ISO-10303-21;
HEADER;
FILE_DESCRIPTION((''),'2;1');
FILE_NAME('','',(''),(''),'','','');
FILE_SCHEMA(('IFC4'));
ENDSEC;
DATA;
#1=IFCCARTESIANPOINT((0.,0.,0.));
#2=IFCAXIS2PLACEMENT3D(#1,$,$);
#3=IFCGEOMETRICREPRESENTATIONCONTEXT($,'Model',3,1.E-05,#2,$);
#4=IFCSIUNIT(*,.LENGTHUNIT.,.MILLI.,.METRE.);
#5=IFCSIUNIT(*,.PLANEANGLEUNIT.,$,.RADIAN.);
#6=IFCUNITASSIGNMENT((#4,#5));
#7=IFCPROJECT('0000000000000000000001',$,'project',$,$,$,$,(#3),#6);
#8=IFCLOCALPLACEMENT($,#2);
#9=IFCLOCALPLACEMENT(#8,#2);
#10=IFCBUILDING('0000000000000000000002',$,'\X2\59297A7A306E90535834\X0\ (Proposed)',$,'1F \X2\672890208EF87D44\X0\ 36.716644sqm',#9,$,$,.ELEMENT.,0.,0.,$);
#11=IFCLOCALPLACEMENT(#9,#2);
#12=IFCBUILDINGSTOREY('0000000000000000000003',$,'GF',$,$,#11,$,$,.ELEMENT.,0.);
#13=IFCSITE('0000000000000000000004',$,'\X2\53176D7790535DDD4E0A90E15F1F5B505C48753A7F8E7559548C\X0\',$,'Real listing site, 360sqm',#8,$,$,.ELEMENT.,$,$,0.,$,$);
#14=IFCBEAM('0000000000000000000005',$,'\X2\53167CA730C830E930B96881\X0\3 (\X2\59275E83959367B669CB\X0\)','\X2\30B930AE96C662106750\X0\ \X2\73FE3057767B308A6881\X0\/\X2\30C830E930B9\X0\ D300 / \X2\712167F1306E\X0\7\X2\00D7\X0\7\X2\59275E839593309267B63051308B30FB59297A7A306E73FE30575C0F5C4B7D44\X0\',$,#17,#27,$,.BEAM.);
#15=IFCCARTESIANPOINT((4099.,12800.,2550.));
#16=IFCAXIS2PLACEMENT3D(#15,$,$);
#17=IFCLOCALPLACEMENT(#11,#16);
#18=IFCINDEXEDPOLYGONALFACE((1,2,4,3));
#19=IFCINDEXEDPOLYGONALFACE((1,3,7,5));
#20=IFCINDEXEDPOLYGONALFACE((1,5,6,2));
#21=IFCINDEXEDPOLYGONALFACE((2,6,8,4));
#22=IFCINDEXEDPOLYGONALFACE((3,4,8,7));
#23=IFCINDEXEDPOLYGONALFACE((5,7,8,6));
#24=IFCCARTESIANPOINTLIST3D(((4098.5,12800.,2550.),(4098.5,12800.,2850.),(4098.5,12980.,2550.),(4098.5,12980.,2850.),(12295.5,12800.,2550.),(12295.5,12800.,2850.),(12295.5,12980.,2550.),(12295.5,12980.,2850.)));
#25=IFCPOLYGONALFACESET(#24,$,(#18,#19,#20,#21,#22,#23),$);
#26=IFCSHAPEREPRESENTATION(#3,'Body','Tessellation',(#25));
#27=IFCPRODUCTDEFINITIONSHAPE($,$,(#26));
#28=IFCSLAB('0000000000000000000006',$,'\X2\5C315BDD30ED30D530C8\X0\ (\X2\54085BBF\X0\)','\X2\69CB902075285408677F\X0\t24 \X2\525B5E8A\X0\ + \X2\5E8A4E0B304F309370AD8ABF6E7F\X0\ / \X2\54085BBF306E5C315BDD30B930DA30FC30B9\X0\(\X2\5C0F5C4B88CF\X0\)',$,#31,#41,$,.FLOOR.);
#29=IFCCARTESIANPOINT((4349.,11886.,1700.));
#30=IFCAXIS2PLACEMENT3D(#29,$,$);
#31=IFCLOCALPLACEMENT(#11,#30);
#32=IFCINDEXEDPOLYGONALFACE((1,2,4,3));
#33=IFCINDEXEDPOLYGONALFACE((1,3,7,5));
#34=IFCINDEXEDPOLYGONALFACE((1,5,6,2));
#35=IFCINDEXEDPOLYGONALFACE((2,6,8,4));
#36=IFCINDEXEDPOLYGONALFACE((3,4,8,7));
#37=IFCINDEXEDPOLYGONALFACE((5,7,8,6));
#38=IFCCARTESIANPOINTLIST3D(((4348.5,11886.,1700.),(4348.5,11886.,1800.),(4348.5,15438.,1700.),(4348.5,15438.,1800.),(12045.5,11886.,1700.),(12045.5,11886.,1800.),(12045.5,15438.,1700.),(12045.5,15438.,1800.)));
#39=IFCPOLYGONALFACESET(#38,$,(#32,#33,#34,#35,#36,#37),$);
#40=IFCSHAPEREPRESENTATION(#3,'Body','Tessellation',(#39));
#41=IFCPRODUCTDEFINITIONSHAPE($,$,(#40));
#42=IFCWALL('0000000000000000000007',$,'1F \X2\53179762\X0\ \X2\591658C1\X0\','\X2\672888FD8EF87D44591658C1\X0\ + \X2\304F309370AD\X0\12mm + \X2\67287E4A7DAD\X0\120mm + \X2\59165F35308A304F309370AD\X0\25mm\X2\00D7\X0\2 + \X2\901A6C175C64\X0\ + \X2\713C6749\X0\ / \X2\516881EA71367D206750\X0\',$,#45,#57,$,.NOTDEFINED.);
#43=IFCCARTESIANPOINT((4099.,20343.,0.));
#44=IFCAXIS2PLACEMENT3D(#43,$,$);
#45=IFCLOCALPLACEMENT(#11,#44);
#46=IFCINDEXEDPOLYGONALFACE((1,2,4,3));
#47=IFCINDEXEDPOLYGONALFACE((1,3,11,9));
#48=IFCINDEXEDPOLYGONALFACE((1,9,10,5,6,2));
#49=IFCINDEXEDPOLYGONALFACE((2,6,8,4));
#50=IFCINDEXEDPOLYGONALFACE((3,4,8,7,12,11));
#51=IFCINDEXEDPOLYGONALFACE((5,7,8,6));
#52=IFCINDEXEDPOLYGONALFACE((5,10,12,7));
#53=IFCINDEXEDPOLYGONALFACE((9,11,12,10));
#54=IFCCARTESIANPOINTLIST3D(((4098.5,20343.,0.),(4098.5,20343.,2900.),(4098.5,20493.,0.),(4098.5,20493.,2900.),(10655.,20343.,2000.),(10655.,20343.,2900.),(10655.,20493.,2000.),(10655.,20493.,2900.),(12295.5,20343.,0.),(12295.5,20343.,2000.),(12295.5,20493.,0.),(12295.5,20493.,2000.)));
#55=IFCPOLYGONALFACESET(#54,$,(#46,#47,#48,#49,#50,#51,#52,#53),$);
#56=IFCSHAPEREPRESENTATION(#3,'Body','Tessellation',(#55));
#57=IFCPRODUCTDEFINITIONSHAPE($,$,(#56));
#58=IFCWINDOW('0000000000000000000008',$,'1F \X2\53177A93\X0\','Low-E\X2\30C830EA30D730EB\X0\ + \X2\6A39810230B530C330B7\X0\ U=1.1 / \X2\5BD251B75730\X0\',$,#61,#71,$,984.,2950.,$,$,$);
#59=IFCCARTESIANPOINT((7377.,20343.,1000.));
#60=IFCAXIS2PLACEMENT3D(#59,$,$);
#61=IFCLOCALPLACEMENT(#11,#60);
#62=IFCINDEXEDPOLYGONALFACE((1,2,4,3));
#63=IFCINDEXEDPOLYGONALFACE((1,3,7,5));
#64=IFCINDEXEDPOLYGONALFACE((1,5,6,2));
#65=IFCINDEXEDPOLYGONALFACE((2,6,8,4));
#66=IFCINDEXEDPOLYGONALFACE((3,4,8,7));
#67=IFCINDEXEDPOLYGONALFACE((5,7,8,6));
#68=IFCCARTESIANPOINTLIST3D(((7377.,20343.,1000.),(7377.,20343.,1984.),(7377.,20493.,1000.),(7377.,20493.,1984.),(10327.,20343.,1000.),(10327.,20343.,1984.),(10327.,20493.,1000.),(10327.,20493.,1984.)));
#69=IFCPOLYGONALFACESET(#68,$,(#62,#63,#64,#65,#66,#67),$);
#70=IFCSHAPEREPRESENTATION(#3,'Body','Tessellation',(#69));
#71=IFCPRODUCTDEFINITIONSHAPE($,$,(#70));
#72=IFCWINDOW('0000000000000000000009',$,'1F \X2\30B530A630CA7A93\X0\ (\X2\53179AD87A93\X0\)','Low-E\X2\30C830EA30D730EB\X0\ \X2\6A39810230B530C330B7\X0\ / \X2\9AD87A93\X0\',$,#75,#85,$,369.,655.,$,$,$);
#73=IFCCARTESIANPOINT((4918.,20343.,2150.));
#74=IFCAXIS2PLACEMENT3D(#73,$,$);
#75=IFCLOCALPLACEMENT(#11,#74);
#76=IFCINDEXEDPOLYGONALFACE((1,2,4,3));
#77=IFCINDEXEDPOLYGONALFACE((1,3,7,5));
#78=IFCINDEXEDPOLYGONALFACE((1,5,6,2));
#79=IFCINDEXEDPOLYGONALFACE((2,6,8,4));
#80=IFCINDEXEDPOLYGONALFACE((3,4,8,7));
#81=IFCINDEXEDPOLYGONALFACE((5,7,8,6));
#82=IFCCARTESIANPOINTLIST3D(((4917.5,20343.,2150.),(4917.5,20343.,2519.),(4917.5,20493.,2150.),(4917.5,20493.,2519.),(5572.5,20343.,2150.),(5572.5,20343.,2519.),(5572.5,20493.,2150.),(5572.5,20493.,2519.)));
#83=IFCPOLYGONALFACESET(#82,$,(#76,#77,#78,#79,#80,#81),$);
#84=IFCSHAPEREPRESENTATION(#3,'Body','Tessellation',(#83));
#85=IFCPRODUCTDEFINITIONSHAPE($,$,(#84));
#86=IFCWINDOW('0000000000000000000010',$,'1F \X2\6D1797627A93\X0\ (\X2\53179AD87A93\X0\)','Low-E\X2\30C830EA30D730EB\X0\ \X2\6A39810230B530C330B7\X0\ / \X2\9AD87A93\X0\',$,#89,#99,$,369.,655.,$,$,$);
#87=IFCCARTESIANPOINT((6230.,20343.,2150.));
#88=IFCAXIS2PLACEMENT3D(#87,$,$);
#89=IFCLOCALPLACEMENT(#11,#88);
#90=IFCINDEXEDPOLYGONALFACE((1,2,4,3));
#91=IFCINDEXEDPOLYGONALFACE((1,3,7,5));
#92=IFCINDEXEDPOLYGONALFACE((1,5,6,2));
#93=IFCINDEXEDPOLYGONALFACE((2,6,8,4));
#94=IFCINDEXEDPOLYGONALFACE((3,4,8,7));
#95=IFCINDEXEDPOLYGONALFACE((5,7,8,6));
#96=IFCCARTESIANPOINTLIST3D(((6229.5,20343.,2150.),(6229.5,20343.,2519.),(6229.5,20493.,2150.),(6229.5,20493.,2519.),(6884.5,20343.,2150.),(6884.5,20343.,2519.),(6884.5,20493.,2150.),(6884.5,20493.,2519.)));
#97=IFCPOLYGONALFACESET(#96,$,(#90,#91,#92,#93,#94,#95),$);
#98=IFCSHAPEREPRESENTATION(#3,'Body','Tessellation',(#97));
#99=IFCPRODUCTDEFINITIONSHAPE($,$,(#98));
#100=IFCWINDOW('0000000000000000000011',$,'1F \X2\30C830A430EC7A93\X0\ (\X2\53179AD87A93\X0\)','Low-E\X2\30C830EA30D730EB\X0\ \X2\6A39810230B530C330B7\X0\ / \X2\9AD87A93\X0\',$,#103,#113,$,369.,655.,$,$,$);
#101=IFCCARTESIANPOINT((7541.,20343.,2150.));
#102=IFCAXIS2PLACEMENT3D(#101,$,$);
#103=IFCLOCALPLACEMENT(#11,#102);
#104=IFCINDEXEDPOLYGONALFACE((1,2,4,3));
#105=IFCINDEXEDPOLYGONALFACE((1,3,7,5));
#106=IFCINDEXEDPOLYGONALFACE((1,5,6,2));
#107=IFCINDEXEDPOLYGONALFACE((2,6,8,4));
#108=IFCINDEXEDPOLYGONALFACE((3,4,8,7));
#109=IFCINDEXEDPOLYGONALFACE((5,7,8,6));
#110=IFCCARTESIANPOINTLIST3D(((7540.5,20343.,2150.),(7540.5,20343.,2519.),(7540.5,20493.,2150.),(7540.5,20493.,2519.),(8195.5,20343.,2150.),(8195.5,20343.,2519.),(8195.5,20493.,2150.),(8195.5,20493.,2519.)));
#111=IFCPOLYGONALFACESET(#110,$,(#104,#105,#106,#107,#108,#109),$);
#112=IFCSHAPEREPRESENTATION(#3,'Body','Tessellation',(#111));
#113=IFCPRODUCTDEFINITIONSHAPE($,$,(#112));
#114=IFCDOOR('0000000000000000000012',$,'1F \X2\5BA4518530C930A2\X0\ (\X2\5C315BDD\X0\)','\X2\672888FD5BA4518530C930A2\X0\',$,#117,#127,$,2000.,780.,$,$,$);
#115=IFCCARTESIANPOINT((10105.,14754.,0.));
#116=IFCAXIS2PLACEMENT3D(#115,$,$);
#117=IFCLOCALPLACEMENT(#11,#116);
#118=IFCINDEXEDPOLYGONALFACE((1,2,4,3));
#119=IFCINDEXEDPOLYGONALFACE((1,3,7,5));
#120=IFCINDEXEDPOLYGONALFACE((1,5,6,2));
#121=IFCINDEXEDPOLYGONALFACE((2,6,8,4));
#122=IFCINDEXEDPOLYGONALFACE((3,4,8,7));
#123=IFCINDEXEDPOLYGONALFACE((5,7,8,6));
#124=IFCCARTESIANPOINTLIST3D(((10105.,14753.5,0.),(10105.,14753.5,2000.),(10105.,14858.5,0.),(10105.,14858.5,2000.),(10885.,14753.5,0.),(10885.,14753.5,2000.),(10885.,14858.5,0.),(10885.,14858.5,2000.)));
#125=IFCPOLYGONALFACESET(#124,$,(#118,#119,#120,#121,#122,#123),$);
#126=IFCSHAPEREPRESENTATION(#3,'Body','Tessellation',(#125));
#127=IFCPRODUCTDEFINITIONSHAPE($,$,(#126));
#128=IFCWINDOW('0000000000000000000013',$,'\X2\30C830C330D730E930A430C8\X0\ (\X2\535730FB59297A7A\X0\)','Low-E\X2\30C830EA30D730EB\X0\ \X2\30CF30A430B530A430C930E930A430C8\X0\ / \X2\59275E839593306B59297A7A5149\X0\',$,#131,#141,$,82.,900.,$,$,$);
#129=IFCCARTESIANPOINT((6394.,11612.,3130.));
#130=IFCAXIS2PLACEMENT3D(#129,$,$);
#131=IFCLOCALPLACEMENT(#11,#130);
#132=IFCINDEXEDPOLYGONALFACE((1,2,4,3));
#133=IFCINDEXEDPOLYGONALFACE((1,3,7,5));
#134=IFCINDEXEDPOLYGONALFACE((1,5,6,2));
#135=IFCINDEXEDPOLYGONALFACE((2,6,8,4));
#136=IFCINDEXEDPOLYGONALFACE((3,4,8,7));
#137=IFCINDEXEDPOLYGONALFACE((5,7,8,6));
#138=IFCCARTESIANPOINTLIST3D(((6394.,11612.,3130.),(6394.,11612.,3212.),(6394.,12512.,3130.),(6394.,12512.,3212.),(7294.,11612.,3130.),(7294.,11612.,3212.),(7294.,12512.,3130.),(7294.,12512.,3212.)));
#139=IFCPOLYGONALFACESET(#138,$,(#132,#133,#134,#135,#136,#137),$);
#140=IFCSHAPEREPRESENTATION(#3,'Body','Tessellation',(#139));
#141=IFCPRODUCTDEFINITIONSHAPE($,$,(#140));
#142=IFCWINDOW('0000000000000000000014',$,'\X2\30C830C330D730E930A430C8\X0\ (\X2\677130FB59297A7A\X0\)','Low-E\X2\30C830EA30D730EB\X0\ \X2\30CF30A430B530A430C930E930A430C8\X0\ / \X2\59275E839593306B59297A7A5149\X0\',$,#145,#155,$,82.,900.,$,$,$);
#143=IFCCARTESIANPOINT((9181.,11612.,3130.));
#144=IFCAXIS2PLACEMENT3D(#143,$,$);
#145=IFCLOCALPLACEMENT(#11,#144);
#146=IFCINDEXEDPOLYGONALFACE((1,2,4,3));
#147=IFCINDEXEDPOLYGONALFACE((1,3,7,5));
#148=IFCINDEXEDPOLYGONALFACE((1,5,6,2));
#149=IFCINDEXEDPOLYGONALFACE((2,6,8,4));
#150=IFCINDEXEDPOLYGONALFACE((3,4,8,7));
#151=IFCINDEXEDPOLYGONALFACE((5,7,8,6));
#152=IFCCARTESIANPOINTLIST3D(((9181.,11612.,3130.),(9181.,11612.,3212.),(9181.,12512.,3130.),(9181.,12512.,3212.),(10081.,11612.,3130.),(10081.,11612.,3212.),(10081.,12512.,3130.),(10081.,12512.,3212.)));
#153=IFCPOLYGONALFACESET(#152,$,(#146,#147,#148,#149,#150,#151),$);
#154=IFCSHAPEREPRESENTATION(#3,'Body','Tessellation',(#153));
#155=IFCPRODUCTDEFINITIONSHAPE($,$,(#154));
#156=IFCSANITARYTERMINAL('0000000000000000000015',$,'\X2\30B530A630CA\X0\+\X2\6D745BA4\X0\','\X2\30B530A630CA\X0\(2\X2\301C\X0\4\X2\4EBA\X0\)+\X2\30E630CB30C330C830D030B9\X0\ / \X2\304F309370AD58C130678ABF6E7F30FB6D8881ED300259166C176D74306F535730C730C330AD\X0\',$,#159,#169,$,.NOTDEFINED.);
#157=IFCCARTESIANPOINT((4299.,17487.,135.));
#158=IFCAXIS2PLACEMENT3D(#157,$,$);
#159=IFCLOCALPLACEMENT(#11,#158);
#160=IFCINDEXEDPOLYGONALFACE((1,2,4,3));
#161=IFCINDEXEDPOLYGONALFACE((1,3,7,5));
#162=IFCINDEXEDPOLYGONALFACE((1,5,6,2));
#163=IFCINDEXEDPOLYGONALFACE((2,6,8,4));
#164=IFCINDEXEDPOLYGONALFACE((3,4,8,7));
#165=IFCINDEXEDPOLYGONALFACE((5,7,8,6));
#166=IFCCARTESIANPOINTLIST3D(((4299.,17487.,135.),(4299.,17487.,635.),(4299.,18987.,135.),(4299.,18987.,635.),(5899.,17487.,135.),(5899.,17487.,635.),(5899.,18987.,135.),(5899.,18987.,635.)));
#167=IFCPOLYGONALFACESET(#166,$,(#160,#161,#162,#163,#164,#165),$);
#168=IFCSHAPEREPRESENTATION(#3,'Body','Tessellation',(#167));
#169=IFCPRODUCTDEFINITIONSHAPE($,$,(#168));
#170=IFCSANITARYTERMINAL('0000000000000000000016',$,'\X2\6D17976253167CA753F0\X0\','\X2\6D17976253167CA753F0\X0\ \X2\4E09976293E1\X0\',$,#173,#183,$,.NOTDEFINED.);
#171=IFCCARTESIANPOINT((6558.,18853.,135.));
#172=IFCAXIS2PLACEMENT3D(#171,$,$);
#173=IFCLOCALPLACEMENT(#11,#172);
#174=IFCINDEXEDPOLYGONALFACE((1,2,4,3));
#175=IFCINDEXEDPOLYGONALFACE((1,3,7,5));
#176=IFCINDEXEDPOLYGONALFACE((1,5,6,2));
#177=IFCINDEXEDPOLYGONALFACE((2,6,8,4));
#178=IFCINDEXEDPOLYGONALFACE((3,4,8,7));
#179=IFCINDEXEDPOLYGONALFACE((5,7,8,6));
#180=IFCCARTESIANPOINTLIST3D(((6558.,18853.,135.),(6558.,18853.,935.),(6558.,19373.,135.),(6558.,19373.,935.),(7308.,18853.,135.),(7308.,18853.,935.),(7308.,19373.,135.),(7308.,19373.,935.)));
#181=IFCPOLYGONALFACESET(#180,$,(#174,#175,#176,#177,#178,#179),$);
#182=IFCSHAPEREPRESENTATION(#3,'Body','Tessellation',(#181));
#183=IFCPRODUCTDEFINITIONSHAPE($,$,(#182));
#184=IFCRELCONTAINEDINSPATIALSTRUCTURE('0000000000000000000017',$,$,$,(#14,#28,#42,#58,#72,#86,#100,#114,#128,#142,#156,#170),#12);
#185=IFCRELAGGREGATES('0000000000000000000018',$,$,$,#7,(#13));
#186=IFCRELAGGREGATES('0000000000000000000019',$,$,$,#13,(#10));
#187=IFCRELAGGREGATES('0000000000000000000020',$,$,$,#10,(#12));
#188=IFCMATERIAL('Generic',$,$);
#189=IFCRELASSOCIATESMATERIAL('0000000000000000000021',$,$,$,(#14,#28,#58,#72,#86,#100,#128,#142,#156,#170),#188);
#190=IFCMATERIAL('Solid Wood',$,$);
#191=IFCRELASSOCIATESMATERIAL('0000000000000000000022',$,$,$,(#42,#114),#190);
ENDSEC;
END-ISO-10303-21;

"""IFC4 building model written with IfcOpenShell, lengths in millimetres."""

from ifc_helpers import new_model, si_unit, frame, frame_2d, origin, place, context, project, spatial, rectangle, extrude, material, element, fill, save


model = new_model("IFC4")

# Units and contexts
model_context = context("Model", 3, precision=1e-05, world=origin())
ifc_project = project(units=[si_unit("LENGTHUNIT", "METRE", prefix="MILLI"), si_unit("PLANEANGLEUNIT", "RADIAN")], contexts=[model_context])

# Site, building, storey
site_placement = place(None, origin())
site = spatial("IfcSite", under=ifc_project, at=site_placement, Name="北海道川上郡弟子屈町美留和", ObjectType="Real listing site, 360sqm", CompositionType="ELEMENT", RefElevation=0.0)
building_placement = place(site_placement, origin())
building = spatial("IfcBuilding", under=site, at=building_placement, Name="天空の道場 (Proposed)", ObjectType="1F 木造軸組 36.716644sqm", CompositionType="ELEMENT", ElevationOfRefHeight=0.0, ElevationOfTerrain=0.0)
storey_placement = place(building_placement, origin())
storey = spatial("IfcBuildingStorey", under=building, at=storey_placement, Name="GF", CompositionType="ELEMENT", Elevation=0.0)

# Beam
ifc_material_1 = material(Name="Generic")
beam_placement = place(storey_placement, frame((4099.0, 12800.0, 2550.0)))
element("IfcBeam", 1, at=beam_placement, inside=storey, material=ifc_material_1, Name="化粧トラス梁3 (大広間架構)", Description="スギ集成材 現し登り梁/トラス D300 / 無柱の7×7大広間を架ける・天空の現し小屋組", PredefinedType="BEAM", context=model_context, shape_type="SweptSolid", body=[
    extrude(rectangle(XDim=8197.0, YDim=180.0, at=frame_2d((4098.0, 90.0))), frame((4099.0, 12800.0, 2550.0)), (0.0, 0.0, 1.0), 300.0),
])

# Slab
slab_placement = place(storey_placement, frame((4349.0, 11886.0, 1700.0)))
element("IfcSlab", 2, at=slab_placement, inside=storey, material=ifc_material_1, Name="就寝ロフト (合宿)", Description="構造用合板t24 剛床 + 床下くん炭調湿 / 合宿の就寝スペース(小屋裏)", PredefinedType="FLOOR", context=model_context, shape_type="SweptSolid", body=[
    extrude(rectangle(XDim=7697.0, YDim=3552.0, at=frame_2d((3848.0, 1776.0))), frame((4349.0, 11886.0, 1700.0)), (0.0, 0.0, 1.0), 100.0),
])

# Wall, openings, windows
ifc_material_2 = material(Name="Solid Wood")
wall_1_placement = place(storey_placement, frame((4099.0, 20343.0, 0.0)))
wall_1 = element("IfcWall", 3, at=wall_1_placement, inside=storey, material=ifc_material_2, Name="1F 北面 外壁", Description="木製軸組外壁 + くん炭12mm + 木繊維120mm + 外張りくん炭25mm×2 + 通気層 + 焼杉 / 全自然素材", PredefinedType="NOTDEFINED", context=model_context, shape_type="SweptSolid", body=[
    extrude(rectangle(XDim=8197.0, YDim=150.0, at=frame_2d((4098.0, 75.0))), frame((4099.0, 20343.0, 0.0)), (0.0, 0.0, 1.0), 2900.0),
])
opening_1_placement = place(storey_placement, frame((7377.0, 20343.0, 1000.0)))
opening_1 = element("IfcOpeningElement", 4, at=opening_1_placement, cuts=wall_1, PredefinedType="NOTDEFINED", context=model_context, shape_type="SweptSolid", body=[
    extrude(rectangle(XDim=2950.0, YDim=150.0, at=frame_2d((1475.0, 75.0))), frame((7377.0, 20343.0, 1000.0)), (0.0, 0.0, 1.0), 984.0),
])
opening_2_placement = place(storey_placement, frame((4918.0, 20343.0, 2150.0)))
opening_2 = element("IfcOpeningElement", 5, at=opening_2_placement, cuts=wall_1, PredefinedType="NOTDEFINED", context=model_context, shape_type="SweptSolid", body=[
    extrude(rectangle(XDim=655.0, YDim=150.0, at=frame_2d((327.0, 75.0))), frame((4918.0, 20343.0, 2150.0)), (0.0, 0.0, 1.0), 369.0),
])
opening_3_placement = place(storey_placement, frame((6230.0, 20343.0, 2150.0)))
opening_3 = element("IfcOpeningElement", 6, at=opening_3_placement, cuts=wall_1, PredefinedType="NOTDEFINED", context=model_context, shape_type="SweptSolid", body=[
    extrude(rectangle(XDim=655.0, YDim=150.0, at=frame_2d((327.0, 75.0))), frame((6230.0, 20343.0, 2150.0)), (0.0, 0.0, 1.0), 369.0),
])
opening_4_placement = place(storey_placement, frame((7541.0, 20343.0, 2150.0)))
opening_4 = element("IfcOpeningElement", 7, at=opening_4_placement, cuts=wall_1, PredefinedType="NOTDEFINED", context=model_context, shape_type="SweptSolid", body=[
    extrude(rectangle(XDim=655.0, YDim=150.0, at=frame_2d((327.0, 75.0))), frame((7541.0, 20343.0, 2150.0)), (0.0, 0.0, 1.0), 369.0),
])
window_1_placement = place(storey_placement, frame((7377.0, 20343.0, 1000.0)))
window_1 = element("IfcWindow", 8, at=window_1_placement, inside=storey, material=ifc_material_1, Name="1F 北窓", Description="Low-Eトリプル + 樹脂サッシ U=1.1 / 寒冷地", OverallHeight=984.0, OverallWidth=2950.0, context=model_context, shape_type="SweptSolid", body=[
    extrude(rectangle(XDim=2950.0, YDim=150.0, at=frame_2d((1475.0, 75.0))), frame((7377.0, 20343.0, 1000.0)), (0.0, 0.0, 1.0), 984.0),
])
fill(opening_1, window_1)
window_2_placement = place(storey_placement, frame((4918.0, 20343.0, 2150.0)))
window_2 = element("IfcWindow", 9, at=window_2_placement, inside=storey, material=ifc_material_1, Name="1F サウナ窓 (北高窓)", Description="Low-Eトリプル 樹脂サッシ / 高窓", OverallHeight=369.0, OverallWidth=655.0, context=model_context, shape_type="SweptSolid", body=[
    extrude(rectangle(XDim=655.0, YDim=150.0, at=frame_2d((327.0, 75.0))), frame((4918.0, 20343.0, 2150.0)), (0.0, 0.0, 1.0), 369.0),
])
fill(opening_2, window_2)
window_3_placement = place(storey_placement, frame((6230.0, 20343.0, 2150.0)))
window_3 = element("IfcWindow", 10, at=window_3_placement, inside=storey, material=ifc_material_1, Name="1F 洗面窓 (北高窓)", Description="Low-Eトリプル 樹脂サッシ / 高窓", OverallHeight=369.0, OverallWidth=655.0, context=model_context, shape_type="SweptSolid", body=[
    extrude(rectangle(XDim=655.0, YDim=150.0, at=frame_2d((327.0, 75.0))), frame((6230.0, 20343.0, 2150.0)), (0.0, 0.0, 1.0), 369.0),
])
fill(opening_3, window_3)
window_4_placement = place(storey_placement, frame((7541.0, 20343.0, 2150.0)))
window_4 = element("IfcWindow", 11, at=window_4_placement, inside=storey, material=ifc_material_1, Name="1F トイレ窓 (北高窓)", Description="Low-Eトリプル 樹脂サッシ / 高窓", OverallHeight=369.0, OverallWidth=655.0, context=model_context, shape_type="SweptSolid", body=[
    extrude(rectangle(XDim=655.0, YDim=150.0, at=frame_2d((327.0, 75.0))), frame((7541.0, 20343.0, 2150.0)), (0.0, 0.0, 1.0), 369.0),
])
fill(opening_4, window_4)

# Door
door_1_placement = place(storey_placement, frame((10105.0, 14754.0, 0.0)))
element("IfcDoor", 12, at=door_1_placement, inside=storey, material=ifc_material_2, Name="1F 室内ドア (就寝)", Description="木製室内ドア", OverallHeight=2000.0, OverallWidth=780.0, context=model_context, shape_type="SweptSolid", body=[
    extrude(rectangle(XDim=780.0, YDim=105.0, at=frame_2d((390.0, 52.0))), frame((10105.0, 14754.0, 0.0)), (0.0, 0.0, 1.0), 2000.0),
])

# Windows
window_5_placement = place(storey_placement, frame((6394.0, 11612.0, 3130.0)))
element("IfcWindow", 13, at=window_5_placement, inside=storey, material=ifc_material_1, Name="トップライト (南・天空)", Description="Low-Eトリプル ハイサイドライト / 大広間に天空光", OverallHeight=82.0, OverallWidth=900.0, context=model_context, shape_type="SweptSolid", body=[
    extrude(rectangle(XDim=900.0, YDim=900.0, at=frame_2d((450.0, 450.0))), frame((6394.0, 11612.0, 3130.0)), (0.0, 0.0, 1.0), 82.0),
])
window_6_placement = place(storey_placement, frame((9181.0, 11612.0, 3130.0)))
element("IfcWindow", 14, at=window_6_placement, inside=storey, material=ifc_material_1, Name="トップライト (東・天空)", Description="Low-Eトリプル ハイサイドライト / 大広間に天空光", OverallHeight=82.0, OverallWidth=900.0, context=model_context, shape_type="SweptSolid", body=[
    extrude(rectangle(XDim=900.0, YDim=900.0, at=frame_2d((450.0, 450.0))), frame((9181.0, 11612.0, 3130.0)), (0.0, 0.0, 1.0), 82.0),
])

# Sanitary terminals
sanitary_terminal_1_placement = place(storey_placement, frame((4299.0, 17487.0, 135.0)))
element("IfcSanitaryTerminal", 15, at=sanitary_terminal_1_placement, inside=storey, material=ifc_material_1, Name="サウナ+浴室", Description="サウナ(2〜4人)+ユニットバス / くん炭壁で調湿・消臭。外気浴は南デッキ", PredefinedType="NOTDEFINED", context=model_context, shape_type="SweptSolid", body=[
    extrude(rectangle(XDim=1600.0, YDim=1500.0, at=frame_2d((800.0, 750.0))), frame((4299.0, 17487.0, 135.0)), (0.0, 0.0, 1.0), 500.0),
])
sanitary_terminal_2_placement = place(storey_placement, frame((6558.0, 18853.0, 135.0)))
element("IfcSanitaryTerminal", 16, at=sanitary_terminal_2_placement, inside=storey, material=ifc_material_1, Name="洗面化粧台", Description="洗面化粧台 三面鏡", PredefinedType="NOTDEFINED", context=model_context, shape_type="SweptSolid", body=[
    extrude(rectangle(XDim=750.0, YDim=520.0, at=frame_2d((375.0, 260.0))), frame((6558.0, 18853.0, 135.0)), (0.0, 0.0, 1.0), 800.0),
])

save(model, "model.ifc")
